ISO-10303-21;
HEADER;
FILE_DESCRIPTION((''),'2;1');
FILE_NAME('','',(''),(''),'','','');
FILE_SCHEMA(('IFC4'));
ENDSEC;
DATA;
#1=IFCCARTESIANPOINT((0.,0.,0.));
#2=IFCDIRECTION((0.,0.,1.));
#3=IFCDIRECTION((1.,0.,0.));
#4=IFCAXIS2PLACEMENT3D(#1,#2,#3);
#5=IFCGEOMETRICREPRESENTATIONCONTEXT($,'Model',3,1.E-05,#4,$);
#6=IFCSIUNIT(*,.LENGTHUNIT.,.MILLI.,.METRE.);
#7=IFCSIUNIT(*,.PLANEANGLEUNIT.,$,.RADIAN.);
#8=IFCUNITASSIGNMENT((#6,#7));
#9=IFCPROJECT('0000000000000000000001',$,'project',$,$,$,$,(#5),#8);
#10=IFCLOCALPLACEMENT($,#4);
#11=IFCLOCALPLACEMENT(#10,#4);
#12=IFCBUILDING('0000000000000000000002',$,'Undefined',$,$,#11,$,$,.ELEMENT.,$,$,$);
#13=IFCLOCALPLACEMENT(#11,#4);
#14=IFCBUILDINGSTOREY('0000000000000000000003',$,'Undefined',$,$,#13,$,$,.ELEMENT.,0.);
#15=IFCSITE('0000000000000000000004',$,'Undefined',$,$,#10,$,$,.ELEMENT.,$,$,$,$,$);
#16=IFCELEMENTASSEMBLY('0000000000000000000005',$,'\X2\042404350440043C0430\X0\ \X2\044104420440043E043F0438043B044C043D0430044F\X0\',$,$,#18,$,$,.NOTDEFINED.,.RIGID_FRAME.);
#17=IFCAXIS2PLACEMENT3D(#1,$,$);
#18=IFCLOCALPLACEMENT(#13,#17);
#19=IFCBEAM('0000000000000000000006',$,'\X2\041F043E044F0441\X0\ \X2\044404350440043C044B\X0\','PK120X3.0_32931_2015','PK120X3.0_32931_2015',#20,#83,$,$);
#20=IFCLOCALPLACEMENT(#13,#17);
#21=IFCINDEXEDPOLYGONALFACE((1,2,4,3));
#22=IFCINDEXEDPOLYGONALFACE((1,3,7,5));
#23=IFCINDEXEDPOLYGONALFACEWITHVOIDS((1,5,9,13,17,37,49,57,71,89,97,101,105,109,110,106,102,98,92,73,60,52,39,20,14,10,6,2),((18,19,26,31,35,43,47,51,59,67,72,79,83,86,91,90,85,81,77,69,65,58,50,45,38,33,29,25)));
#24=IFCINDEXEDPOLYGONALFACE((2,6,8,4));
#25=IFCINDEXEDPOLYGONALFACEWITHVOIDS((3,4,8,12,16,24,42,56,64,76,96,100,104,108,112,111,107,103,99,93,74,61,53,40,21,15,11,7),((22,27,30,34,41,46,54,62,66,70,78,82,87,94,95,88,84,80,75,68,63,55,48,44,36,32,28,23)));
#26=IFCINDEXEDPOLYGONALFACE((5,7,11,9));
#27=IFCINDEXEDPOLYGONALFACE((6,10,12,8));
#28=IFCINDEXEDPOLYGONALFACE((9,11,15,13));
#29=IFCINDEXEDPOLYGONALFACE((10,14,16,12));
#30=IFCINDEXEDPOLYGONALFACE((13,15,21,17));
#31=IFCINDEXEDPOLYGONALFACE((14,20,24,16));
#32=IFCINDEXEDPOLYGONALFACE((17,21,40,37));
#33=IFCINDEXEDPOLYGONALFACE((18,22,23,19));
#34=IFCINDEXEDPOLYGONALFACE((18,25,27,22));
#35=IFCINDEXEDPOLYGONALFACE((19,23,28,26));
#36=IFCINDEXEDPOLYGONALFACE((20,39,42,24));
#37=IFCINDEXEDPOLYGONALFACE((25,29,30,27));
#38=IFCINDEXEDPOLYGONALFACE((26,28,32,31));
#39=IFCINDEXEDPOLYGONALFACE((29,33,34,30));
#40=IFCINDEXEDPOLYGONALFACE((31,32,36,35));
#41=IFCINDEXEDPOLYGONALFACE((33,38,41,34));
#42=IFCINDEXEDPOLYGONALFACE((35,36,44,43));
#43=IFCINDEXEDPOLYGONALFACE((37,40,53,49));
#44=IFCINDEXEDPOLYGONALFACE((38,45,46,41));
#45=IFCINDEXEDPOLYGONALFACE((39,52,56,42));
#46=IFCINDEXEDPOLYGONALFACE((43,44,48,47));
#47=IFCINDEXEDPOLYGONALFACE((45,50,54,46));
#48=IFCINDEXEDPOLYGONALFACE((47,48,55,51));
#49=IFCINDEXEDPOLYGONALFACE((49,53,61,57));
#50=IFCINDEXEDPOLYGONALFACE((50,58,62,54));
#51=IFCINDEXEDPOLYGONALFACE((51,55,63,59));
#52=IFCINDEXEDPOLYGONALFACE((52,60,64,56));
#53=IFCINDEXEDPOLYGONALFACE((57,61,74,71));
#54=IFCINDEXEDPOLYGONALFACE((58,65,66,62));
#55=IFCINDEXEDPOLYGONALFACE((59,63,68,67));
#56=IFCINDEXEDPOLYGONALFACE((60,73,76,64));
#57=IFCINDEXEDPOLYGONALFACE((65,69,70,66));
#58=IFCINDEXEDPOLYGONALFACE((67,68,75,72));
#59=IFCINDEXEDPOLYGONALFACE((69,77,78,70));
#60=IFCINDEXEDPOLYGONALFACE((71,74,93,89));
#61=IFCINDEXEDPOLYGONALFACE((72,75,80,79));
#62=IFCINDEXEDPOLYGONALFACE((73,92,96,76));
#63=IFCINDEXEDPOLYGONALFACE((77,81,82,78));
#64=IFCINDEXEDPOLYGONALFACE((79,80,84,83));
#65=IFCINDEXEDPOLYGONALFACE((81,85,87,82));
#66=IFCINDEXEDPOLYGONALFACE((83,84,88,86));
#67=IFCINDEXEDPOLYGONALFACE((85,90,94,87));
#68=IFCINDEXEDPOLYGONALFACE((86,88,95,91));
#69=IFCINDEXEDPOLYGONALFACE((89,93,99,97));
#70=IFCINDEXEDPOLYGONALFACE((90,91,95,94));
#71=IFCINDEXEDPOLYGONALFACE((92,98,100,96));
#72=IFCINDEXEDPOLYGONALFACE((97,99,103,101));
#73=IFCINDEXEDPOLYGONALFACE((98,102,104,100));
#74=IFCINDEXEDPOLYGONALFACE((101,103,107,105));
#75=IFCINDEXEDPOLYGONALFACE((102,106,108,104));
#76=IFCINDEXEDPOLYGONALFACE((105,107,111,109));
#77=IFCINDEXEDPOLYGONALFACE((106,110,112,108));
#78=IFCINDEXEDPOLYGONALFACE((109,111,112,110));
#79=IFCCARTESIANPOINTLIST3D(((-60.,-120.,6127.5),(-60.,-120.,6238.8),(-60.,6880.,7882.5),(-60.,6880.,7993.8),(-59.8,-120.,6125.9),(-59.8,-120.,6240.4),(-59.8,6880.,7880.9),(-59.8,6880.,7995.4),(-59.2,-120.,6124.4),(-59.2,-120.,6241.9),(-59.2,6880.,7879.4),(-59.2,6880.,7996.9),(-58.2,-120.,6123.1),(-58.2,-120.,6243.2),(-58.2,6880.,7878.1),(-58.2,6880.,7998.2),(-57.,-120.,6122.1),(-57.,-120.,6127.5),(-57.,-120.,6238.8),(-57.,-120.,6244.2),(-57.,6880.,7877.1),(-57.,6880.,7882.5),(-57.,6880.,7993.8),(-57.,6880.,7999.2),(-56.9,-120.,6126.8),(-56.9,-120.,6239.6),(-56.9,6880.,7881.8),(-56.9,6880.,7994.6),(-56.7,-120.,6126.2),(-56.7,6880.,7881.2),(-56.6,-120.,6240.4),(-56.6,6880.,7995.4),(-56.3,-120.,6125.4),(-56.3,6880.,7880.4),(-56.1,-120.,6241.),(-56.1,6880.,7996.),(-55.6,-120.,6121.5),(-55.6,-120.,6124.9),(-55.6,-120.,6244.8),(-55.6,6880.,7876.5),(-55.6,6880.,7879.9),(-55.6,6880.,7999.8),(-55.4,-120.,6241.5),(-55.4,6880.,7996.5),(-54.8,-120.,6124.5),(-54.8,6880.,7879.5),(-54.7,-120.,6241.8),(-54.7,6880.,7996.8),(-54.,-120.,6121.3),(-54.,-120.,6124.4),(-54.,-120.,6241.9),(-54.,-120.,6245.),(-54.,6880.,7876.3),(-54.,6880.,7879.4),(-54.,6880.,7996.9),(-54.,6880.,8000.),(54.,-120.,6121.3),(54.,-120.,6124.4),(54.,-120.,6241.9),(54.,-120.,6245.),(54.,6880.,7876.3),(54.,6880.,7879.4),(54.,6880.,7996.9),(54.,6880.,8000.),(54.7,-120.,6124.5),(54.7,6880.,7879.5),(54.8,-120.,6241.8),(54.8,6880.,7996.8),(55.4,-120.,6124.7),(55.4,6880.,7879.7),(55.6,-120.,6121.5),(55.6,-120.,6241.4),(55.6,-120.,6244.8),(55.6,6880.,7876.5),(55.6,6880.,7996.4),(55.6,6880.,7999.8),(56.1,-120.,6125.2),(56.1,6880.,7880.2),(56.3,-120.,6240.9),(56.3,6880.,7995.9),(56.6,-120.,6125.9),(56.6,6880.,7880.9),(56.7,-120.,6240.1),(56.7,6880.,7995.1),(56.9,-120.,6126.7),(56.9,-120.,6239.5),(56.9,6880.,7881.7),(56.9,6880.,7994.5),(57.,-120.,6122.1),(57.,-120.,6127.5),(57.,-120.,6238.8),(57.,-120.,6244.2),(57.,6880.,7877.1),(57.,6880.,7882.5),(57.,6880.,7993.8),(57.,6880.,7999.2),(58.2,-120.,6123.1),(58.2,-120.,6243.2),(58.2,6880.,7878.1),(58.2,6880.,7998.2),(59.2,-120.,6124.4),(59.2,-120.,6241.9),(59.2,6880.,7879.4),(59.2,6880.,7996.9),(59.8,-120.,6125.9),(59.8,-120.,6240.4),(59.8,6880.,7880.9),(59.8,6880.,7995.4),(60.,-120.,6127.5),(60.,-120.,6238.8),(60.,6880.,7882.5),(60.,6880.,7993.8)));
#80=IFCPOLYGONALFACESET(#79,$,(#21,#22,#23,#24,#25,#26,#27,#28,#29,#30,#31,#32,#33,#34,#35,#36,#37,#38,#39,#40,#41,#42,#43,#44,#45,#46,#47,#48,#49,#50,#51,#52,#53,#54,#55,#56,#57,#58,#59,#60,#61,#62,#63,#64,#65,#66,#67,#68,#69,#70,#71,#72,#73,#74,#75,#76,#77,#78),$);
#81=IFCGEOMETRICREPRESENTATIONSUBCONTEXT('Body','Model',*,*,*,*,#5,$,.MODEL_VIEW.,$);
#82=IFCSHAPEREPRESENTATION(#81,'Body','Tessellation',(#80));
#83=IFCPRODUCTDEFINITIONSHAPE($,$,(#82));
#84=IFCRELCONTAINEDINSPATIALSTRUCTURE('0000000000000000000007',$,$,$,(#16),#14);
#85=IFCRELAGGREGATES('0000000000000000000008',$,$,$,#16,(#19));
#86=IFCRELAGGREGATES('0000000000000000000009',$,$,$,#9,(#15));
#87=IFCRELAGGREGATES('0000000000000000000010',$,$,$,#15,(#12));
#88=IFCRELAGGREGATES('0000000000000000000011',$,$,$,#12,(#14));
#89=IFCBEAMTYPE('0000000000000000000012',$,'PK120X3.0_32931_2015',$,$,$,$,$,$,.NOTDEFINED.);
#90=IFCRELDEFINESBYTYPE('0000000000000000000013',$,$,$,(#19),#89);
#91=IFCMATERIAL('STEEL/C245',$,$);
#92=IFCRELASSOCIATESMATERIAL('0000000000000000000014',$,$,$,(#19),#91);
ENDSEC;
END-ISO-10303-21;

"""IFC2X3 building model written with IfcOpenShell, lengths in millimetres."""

from ifc_helpers import new_model, si_unit, frame, origin_with_axes, origin_2d_with_axis, place, context, subcontext, project, spatial, hollow_rectangle, extrude, clip, halfspace, material, type_object, element, aggregate, save


model = new_model("IFC2X3")

# Units and contexts
model_context = context("Model", 3, precision=1e-05, world=origin_with_axes())
body_context = subcontext(model_context, "Body", "Model", "MODEL_VIEW")
ifc_project = project(units=[si_unit("LENGTHUNIT", "METRE", prefix="MILLI"), si_unit("PLANEANGLEUNIT", "RADIAN")], contexts=[model_context])

# Site, building, storey
site_placement = place(None, origin_with_axes())
site = spatial("IfcSite", under=ifc_project, at=site_placement, Name="Undefined", CompositionType="ELEMENT")
building_placement = place(site_placement, origin_with_axes())
building = spatial("IfcBuilding", under=site, at=building_placement, Name="Undefined", CompositionType="ELEMENT")
storey_placement = place(building_placement, origin_with_axes())
storey = spatial("IfcBuildingStorey", under=building, at=storey_placement, Name="Undefined", CompositionType="ELEMENT", Elevation=0.0)

# Shared definitions
ifc_material = material(Name="STEEL/C245")

# Element assembly
assembly_1_placement = place(storey_placement, origin_with_axes())
assembly_1 = element("IfcElementAssembly", 1, at=assembly_1_placement, inside=storey, Name="Ферма стропильная", AssemblyPlace="NOTDEFINED", PredefinedType="RIGID_FRAME")

# Beam
beam_type_1 = type_object("IfcBeamType", Name="PK120X3.0_32931_2015", PredefinedType="NOTDEFINED")
beam_1_placement = place(assembly_1_placement, frame((0.0, -105.4, 6186.8), z_axis=(0.0, -0.243188, 0.969979), x_axis=(0.0, 0.969979, 0.243188)))
beam_1 = element("IfcBeam", 2, at=beam_1_placement, type_object=beam_type_1, material=ifc_material, Name="Пояс фермы", Description="PK120X3.0_32931_2015", ObjectType="PK120X3.0_32931_2015", context=body_context, shape_type="Clipping", body=[
    clip(clip(extrude(hollow_rectangle(XDim=120.0, YDim=120.0, WallThickness=3.0, InnerFilletRadius=3.0, OuterFilletRadius=6.0, at=origin_2d_with_axis()), frame((7232.0, 0.0, 0.0), z_axis=(-1.0, 0.0, 0.0), x_axis=(0.0, -1.0, 0.0)), (0.0, 0.0, 1.0), 7277.4), halfspace(frame((7216.6, 0.0, 60.0), z_axis=(0.969979, 0.0, -0.243188), x_axis=(0.0, -1.0, 0.0)), False)), halfspace(frame((0.0, 0.0, 60.0), z_axis=(0.969979, 0.0, -0.243188), x_axis=(0.0, -1.0, 0.0)), True)),
])
aggregate(assembly_1, [beam_1])

save(model, "model.ifc")
